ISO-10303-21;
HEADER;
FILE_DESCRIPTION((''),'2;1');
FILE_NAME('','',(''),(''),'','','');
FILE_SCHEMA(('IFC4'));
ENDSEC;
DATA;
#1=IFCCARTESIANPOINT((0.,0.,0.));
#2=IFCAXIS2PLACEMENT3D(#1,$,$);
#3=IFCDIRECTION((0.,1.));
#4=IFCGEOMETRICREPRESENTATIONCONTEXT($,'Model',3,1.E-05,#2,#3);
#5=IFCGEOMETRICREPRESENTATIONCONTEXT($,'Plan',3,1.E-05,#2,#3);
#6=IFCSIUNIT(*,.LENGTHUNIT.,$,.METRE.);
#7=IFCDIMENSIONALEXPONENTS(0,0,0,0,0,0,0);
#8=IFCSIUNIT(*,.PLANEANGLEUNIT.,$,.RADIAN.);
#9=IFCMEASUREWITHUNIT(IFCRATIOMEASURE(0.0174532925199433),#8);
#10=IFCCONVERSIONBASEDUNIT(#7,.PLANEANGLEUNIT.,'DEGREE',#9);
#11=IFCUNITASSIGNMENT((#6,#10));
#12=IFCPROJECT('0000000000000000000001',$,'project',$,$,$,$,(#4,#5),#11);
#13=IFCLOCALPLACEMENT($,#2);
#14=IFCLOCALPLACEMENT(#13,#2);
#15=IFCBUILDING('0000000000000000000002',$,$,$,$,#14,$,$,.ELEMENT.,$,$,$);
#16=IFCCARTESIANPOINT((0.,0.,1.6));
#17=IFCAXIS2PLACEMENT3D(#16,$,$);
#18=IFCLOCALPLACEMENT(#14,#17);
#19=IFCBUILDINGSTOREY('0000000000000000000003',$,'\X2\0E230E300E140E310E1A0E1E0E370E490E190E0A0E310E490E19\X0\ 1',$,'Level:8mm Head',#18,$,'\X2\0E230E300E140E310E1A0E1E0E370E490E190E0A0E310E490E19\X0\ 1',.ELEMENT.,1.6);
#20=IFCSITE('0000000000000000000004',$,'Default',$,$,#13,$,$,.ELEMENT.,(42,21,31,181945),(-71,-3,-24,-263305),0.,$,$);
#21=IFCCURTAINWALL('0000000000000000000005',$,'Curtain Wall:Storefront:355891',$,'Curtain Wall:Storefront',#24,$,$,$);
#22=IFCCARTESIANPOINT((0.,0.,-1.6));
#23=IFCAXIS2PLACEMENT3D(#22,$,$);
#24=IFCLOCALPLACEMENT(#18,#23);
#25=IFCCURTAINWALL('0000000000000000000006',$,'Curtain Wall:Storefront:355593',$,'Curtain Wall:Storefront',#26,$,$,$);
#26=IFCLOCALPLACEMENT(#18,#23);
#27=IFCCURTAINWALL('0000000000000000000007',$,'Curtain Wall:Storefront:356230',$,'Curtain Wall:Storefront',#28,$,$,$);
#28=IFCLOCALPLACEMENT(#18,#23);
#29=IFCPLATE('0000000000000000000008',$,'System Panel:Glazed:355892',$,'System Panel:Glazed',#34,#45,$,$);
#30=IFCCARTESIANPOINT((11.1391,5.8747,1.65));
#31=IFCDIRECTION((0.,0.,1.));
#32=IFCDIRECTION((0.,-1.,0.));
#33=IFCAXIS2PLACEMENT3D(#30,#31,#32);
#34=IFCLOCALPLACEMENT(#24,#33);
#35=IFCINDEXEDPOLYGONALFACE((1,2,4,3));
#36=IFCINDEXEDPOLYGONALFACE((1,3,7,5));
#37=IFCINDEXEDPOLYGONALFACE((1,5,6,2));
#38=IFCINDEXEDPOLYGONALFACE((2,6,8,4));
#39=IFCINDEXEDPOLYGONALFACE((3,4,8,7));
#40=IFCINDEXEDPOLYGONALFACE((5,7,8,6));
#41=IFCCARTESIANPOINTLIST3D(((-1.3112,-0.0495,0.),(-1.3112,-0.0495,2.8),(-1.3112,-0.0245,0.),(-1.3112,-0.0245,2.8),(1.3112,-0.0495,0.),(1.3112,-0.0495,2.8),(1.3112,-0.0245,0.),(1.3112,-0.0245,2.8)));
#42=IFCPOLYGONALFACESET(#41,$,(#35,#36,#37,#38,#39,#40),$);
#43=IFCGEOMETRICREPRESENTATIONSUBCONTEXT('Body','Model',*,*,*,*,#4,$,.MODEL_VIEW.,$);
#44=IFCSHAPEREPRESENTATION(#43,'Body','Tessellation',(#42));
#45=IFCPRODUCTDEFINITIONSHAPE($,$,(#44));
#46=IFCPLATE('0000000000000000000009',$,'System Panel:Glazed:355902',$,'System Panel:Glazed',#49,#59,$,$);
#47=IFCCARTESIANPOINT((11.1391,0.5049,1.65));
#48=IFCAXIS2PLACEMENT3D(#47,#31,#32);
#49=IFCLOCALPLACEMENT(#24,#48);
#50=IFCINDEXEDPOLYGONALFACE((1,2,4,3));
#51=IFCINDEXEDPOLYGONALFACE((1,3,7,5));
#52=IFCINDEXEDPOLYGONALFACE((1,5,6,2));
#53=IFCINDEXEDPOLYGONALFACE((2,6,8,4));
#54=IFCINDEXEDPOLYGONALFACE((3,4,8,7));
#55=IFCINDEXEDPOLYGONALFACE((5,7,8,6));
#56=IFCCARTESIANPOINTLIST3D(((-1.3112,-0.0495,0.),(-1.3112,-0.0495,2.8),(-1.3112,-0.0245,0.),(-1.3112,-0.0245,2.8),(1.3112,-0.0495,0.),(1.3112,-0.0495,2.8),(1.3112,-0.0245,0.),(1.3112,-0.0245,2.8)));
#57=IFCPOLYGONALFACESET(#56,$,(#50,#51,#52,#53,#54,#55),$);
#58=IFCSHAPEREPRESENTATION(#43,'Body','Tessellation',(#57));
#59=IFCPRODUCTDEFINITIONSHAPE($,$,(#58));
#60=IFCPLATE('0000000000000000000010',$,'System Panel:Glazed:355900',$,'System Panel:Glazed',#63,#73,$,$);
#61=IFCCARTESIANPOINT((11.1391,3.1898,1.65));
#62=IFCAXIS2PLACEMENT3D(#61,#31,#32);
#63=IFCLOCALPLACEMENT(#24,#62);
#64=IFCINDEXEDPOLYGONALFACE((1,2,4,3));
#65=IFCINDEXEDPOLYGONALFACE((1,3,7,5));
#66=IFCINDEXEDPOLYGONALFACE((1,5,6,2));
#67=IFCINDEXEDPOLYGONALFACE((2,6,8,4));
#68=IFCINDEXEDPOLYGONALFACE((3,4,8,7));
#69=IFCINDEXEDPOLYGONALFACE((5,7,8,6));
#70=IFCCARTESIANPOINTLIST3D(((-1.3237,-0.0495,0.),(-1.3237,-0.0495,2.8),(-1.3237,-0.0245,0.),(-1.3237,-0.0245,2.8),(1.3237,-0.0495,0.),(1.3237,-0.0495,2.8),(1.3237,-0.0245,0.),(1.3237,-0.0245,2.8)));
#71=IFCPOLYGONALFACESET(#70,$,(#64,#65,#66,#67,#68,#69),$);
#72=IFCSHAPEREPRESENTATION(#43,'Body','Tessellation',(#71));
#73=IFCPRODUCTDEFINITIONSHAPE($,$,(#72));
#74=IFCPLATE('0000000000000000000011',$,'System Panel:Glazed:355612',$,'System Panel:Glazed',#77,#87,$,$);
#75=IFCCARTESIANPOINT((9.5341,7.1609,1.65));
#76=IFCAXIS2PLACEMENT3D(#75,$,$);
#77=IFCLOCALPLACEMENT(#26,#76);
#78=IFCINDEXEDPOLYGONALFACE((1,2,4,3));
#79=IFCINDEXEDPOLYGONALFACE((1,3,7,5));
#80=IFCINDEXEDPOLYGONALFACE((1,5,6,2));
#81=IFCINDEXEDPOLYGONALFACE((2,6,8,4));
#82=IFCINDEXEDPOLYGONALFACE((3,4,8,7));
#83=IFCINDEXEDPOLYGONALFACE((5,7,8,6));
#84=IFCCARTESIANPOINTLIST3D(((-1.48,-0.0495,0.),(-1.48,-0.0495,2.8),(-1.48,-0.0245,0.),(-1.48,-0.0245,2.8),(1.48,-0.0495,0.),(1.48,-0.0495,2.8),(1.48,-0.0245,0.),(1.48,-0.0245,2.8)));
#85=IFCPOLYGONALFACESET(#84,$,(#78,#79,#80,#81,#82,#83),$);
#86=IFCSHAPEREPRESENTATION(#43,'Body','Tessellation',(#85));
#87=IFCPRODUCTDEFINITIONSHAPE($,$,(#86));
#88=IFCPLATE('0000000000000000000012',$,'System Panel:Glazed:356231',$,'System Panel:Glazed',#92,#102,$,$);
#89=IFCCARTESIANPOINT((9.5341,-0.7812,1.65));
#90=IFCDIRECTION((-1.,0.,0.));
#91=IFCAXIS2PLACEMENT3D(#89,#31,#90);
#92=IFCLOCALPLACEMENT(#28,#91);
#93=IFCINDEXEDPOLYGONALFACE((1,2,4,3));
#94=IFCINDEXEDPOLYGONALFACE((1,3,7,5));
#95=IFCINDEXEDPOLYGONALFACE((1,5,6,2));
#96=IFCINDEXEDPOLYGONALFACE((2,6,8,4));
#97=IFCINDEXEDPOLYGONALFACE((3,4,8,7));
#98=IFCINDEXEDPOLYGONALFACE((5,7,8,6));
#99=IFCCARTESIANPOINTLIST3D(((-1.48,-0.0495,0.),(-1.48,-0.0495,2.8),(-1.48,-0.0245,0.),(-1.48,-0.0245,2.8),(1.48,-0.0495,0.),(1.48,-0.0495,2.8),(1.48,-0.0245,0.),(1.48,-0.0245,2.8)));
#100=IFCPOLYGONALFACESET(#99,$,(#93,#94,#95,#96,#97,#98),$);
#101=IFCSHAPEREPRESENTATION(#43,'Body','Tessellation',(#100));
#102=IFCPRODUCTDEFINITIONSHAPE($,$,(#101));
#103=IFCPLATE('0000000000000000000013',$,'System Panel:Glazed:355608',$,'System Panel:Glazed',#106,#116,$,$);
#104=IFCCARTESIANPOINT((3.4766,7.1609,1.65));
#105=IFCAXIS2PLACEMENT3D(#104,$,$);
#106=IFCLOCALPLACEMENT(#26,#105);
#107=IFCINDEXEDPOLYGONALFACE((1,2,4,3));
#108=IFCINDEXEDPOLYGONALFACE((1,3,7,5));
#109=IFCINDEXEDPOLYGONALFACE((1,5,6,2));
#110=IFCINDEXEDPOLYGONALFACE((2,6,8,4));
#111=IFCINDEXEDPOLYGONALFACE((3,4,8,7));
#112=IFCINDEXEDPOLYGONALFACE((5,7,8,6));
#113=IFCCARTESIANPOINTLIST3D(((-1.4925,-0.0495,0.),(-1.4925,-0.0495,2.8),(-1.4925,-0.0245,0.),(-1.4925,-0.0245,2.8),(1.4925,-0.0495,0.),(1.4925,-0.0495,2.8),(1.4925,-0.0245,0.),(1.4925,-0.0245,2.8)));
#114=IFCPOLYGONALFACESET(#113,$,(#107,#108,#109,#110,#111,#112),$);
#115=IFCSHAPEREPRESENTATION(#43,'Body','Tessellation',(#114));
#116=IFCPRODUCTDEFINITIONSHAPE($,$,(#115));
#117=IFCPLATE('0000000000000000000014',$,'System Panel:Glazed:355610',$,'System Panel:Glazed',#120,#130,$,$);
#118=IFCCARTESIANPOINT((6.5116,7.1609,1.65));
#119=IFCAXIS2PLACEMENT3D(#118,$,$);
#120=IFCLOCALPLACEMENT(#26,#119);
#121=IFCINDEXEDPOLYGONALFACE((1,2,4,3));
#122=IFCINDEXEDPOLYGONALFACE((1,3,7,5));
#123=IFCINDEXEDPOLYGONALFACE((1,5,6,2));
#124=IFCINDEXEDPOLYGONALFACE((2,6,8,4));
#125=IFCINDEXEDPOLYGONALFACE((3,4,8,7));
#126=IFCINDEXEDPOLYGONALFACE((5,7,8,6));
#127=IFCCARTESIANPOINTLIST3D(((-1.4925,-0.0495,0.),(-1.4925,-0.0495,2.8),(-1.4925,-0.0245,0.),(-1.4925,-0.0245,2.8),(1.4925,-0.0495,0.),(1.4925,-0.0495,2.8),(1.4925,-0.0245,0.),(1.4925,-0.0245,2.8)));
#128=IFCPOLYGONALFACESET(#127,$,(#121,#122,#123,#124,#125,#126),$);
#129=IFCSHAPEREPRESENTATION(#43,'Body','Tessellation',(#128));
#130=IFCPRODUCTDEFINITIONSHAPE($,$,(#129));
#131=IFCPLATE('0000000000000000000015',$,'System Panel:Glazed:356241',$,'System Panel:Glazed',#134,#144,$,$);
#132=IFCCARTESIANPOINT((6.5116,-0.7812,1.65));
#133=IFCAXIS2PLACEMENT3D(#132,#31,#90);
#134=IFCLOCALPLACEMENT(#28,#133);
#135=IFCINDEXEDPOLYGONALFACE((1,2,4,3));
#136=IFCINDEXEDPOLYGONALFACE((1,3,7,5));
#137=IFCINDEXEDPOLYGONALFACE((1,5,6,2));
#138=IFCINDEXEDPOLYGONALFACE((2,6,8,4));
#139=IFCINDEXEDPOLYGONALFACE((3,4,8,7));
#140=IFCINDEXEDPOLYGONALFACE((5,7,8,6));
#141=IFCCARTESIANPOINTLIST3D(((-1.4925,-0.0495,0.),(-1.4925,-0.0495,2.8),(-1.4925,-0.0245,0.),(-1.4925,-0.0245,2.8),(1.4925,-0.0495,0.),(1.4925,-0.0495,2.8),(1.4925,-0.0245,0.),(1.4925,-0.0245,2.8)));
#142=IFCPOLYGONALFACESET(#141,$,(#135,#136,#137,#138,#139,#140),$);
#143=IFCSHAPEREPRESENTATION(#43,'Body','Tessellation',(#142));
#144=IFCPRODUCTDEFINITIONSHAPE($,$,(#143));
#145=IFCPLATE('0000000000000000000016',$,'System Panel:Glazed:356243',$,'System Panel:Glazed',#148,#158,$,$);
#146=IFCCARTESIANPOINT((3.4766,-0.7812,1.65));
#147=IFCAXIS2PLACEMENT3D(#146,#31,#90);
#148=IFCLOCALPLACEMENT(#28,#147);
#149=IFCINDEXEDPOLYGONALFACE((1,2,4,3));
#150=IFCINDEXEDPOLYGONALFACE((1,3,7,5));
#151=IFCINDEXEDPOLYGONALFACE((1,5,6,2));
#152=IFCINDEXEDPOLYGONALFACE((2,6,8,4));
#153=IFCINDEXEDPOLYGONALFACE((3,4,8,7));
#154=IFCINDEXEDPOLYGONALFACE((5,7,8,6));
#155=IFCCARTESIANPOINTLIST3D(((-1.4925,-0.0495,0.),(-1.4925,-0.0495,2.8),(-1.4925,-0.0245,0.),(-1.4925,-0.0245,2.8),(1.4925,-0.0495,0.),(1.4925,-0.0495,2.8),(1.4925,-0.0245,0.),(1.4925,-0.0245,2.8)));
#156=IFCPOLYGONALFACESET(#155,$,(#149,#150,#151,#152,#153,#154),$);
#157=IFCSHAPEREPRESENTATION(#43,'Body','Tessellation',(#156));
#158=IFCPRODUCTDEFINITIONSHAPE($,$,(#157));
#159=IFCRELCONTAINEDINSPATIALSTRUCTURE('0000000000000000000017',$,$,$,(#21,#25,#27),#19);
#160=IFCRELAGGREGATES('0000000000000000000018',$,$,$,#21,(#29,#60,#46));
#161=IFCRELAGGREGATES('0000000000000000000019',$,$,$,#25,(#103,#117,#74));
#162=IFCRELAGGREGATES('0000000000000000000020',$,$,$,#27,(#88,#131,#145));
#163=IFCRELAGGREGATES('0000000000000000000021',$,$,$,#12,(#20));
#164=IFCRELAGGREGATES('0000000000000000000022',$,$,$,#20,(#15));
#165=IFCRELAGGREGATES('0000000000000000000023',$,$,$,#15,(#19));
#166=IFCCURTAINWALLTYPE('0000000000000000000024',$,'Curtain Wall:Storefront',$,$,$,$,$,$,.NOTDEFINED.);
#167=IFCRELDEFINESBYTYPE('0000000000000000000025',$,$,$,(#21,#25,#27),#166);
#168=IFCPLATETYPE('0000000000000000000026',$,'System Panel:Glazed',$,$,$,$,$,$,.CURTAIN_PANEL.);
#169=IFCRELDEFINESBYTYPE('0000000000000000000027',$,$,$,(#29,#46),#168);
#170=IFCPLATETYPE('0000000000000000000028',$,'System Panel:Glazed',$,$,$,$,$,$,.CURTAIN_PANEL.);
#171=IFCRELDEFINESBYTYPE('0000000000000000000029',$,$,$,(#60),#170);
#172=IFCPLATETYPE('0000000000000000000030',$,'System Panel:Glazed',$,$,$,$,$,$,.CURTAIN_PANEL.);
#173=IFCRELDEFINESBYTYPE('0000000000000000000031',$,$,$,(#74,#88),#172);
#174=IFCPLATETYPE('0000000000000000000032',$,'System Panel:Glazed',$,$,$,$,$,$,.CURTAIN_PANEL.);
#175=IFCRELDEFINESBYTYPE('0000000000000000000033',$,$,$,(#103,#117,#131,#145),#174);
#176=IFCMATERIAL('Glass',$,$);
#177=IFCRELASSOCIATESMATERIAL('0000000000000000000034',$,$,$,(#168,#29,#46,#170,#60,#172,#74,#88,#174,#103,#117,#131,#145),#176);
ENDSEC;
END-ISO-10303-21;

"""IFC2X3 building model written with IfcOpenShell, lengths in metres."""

from ifc_helpers import new_model, entity, si_unit, converted_unit, direction, frame, frame_2d, origin, origin_2d_with_axis, place, context, subcontext, project, spatial, rectangle, extrude, source, transform, mapped, material, type_object, type_shapes, element, aggregate, save


model = new_model("IFC2X3")

# Units and contexts
model_context = context("Model", 3, precision=1e-05, world=origin(), true_north=direction((0.0, 1.0)))
plan_context = context("Plan", 3, precision=1e-05, world=origin(), true_north=direction((0.0, 1.0)))
body_context = subcontext(model_context, "Body", "Model", "MODEL_VIEW")
ifc_project = project(units=[si_unit("LENGTHUNIT", "METRE"), converted_unit("PLANEANGLEUNIT", "DEGREE", entity("IfcRatioMeasure", 0.0174532925199433), si_unit("PLANEANGLEUNIT", "RADIAN"), dimensions=[0, 0, 0, 0, 0, 0, 0])], contexts=[model_context, plan_context])

# Site, building, storey
site_placement = place(None, origin())
site = spatial("IfcSite", under=ifc_project, at=site_placement, Name="Default", CompositionType="ELEMENT", RefLatitude=(42, 21, 31, 181945), RefLongitude=(-71, -3, -24, -263305), RefElevation=0.0)
building_placement = place(site_placement, origin())
building = spatial("IfcBuilding", under=site, at=building_placement, CompositionType="ELEMENT")
storey_placement = place(building_placement, frame((0.0, 0.0, 1.6)))
storey = spatial("IfcBuildingStorey", under=building, at=storey_placement, Name="ระดับพื้นชั้น 1", ObjectType="Level:8mm Head", LongName="ระดับพื้นชั้น 1", CompositionType="ELEMENT", Elevation=1.6)

# Curtain wall
curtain_wall_type = type_object("IfcCurtainWallType", Name="Curtain Wall:Storefront", PredefinedType="NOTDEFINED")
curtain_wall_1_placement = place(storey_placement, frame((0.0, 0.0, -1.6)))
curtain_wall_1 = element("IfcCurtainWall", 1, at=curtain_wall_1_placement, inside=storey, type_object=curtain_wall_type, Name="Curtain Wall:Storefront:355891", ObjectType="Curtain Wall:Storefront")

# Curtain wall
curtain_wall_2_placement = place(storey_placement, frame((0.0, 0.0, -1.6)))
curtain_wall_2 = element("IfcCurtainWall", 2, at=curtain_wall_2_placement, inside=storey, type_object=curtain_wall_type, Name="Curtain Wall:Storefront:355593", ObjectType="Curtain Wall:Storefront")

# Curtain wall
curtain_wall_3_placement = place(storey_placement, frame((0.0, 0.0, -1.6)))
curtain_wall_3 = element("IfcCurtainWall", 3, at=curtain_wall_3_placement, inside=storey, type_object=curtain_wall_type, Name="Curtain Wall:Storefront:356230", ObjectType="Curtain Wall:Storefront")

# Plates
ifc_material_1 = material(Name="Glass")
plate_type_1 = type_object("IfcPlateType", Name="System Panel:Glazed", PredefinedType="CURTAIN_PANEL", material=ifc_material_1)
shared_shape_1 = source(origin(), body_context, "Body", "SweptSolid", [
    extrude(rectangle(XDim=0.025, YDim=2.6224, at=frame_2d((0.0, 0.0), x_axis=(1.0, 0.0))), frame((0.0, -0.037, 0.0), z_axis=(0.0, 0.0, 1.0), x_axis=(0.0, 1.0, 0.0)), (0.0, 0.0, 1.0), 2.8),
])
type_shapes(plate_type_1, [shared_shape_1])
plate_1_placement = place(curtain_wall_1_placement, frame((11.1391, 5.8747, 1.65), z_axis=(0.0, 0.0, 1.0), x_axis=(0.0, -1.0, 0.0)))
plate_1 = element("IfcPlate", 4, at=plate_1_placement, type_object=plate_type_1, material=ifc_material_1, Name="System Panel:Glazed:355892", ObjectType="System Panel:Glazed", context=body_context, shape_type="MappedRepresentation", body=[
    mapped(shared_shape_1, transform((0.0, 0.0, 0.0), scale=1.0)),
])
plate_2_placement = place(curtain_wall_1_placement, frame((11.1391, 0.5049, 1.65), z_axis=(0.0, 0.0, 1.0), x_axis=(0.0, -1.0, 0.0)))
plate_2 = element("IfcPlate", 5, at=plate_2_placement, type_object=plate_type_1, material=ifc_material_1, Name="System Panel:Glazed:355902", ObjectType="System Panel:Glazed", context=body_context, shape_type="MappedRepresentation", body=[
    mapped(shared_shape_1, transform((0.0, 0.0, 0.0), scale=1.0)),
])
plate_type_2 = type_object("IfcPlateType", Name="System Panel:Glazed", PredefinedType="CURTAIN_PANEL", material=ifc_material_1)
shared_shape_2 = source(origin(), body_context, "Body", "SweptSolid", [
    extrude(rectangle(XDim=0.025, YDim=2.6474, at=origin_2d_with_axis()), frame((0.0, -0.037, 0.0), z_axis=(0.0, 0.0, 1.0), x_axis=(0.0, 1.0, 0.0)), (0.0, 0.0, 1.0), 2.8),
])
type_shapes(plate_type_2, [shared_shape_2])
plate_3_placement = place(curtain_wall_1_placement, frame((11.1391, 3.1898, 1.65), z_axis=(0.0, 0.0, 1.0), x_axis=(0.0, -1.0, 0.0)))
plate_3 = element("IfcPlate", 6, at=plate_3_placement, type_object=plate_type_2, material=ifc_material_1, Name="System Panel:Glazed:355900", ObjectType="System Panel:Glazed", context=body_context, shape_type="MappedRepresentation", body=[
    mapped(shared_shape_2, transform((0.0, 0.0, 0.0), scale=1.0)),
])
aggregate(curtain_wall_1, [plate_1, plate_3, plate_2])
plate_type_3 = type_object("IfcPlateType", Name="System Panel:Glazed", PredefinedType="CURTAIN_PANEL", material=ifc_material_1)
shared_shape_3 = source(origin(), body_context, "Body", "SweptSolid", [
    extrude(rectangle(XDim=0.025, YDim=2.96, at=frame_2d((0.0, 0.0), x_axis=(1.0, 0.0))), frame((0.0, -0.037, 0.0), z_axis=(0.0, 0.0, 1.0), x_axis=(0.0, 1.0, 0.0)), (0.0, 0.0, 1.0), 2.8),
])
type_shapes(plate_type_3, [shared_shape_3])
plate_4_placement = place(curtain_wall_2_placement, frame((9.5341, 7.1609, 1.65)))
plate_4 = element("IfcPlate", 7, at=plate_4_placement, type_object=plate_type_3, material=ifc_material_1, Name="System Panel:Glazed:355612", ObjectType="System Panel:Glazed", context=body_context, shape_type="MappedRepresentation", body=[
    mapped(shared_shape_3, transform((0.0, 0.0, 0.0), scale=1.0)),
])
plate_5_placement = place(curtain_wall_3_placement, frame((9.5341, -0.7812, 1.65), z_axis=(0.0, 0.0, 1.0), x_axis=(-1.0, 0.0, 0.0)))
plate_5 = element("IfcPlate", 8, at=plate_5_placement, type_object=plate_type_3, material=ifc_material_1, Name="System Panel:Glazed:356231", ObjectType="System Panel:Glazed", context=body_context, shape_type="MappedRepresentation", body=[
    mapped(shared_shape_3, transform((0.0, 0.0, 0.0), scale=1.0)),
])
plate_type_4 = type_object("IfcPlateType", Name="System Panel:Glazed", PredefinedType="CURTAIN_PANEL", material=ifc_material_1)
shared_shape_4 = source(origin(), body_context, "Body", "SweptSolid", [
    extrude(rectangle(XDim=0.025, YDim=2.985, at=frame_2d((0.0, 0.0), x_axis=(1.0, 0.0))), frame((0.0, -0.037, 0.0), z_axis=(0.0, 0.0, 1.0), x_axis=(0.0, 1.0, 0.0)), (0.0, 0.0, 1.0), 2.8),
])
type_shapes(plate_type_4, [shared_shape_4])
plate_6_placement = place(curtain_wall_2_placement, frame((3.4766, 7.1609, 1.65)))
plate_6 = element("IfcPlate", 9, at=plate_6_placement, type_object=plate_type_4, material=ifc_material_1, Name="System Panel:Glazed:355608", ObjectType="System Panel:Glazed", context=body_context, shape_type="MappedRepresentation", body=[
    mapped(shared_shape_4, transform((0.0, 0.0, 0.0), scale=1.0)),
])
plate_7_placement = place(curtain_wall_2_placement, frame((6.5116, 7.1609, 1.65)))
plate_7 = element("IfcPlate", 10, at=plate_7_placement, type_object=plate_type_4, material=ifc_material_1, Name="System Panel:Glazed:355610", ObjectType="System Panel:Glazed", context=body_context, shape_type="MappedRepresentation", body=[
    mapped(shared_shape_4, transform((0.0, 0.0, 0.0), scale=1.0)),
])
aggregate(curtain_wall_2, [plate_6, plate_7, plate_4])
plate_8_placement = place(curtain_wall_3_placement, frame((6.5116, -0.7812, 1.65), z_axis=(0.0, 0.0, 1.0), x_axis=(-1.0, 0.0, 0.0)))
plate_8 = element("IfcPlate", 11, at=plate_8_placement, type_object=plate_type_4, material=ifc_material_1, Name="System Panel:Glazed:356241", ObjectType="System Panel:Glazed", context=body_context, shape_type="MappedRepresentation", body=[
    mapped(shared_shape_4, transform((0.0, 0.0, 0.0), scale=1.0)),
])
plate_9_placement = place(curtain_wall_3_placement, frame((3.4766, -0.7812, 1.65), z_axis=(0.0, 0.0, 1.0), x_axis=(-1.0, 0.0, 0.0)))
plate_9 = element("IfcPlate", 12, at=plate_9_placement, type_object=plate_type_4, material=ifc_material_1, Name="System Panel:Glazed:356243", ObjectType="System Panel:Glazed", context=body_context, shape_type="MappedRepresentation", body=[
    mapped(shared_shape_4, transform((0.0, 0.0, 0.0), scale=1.0)),
])
aggregate(curtain_wall_3, [plate_5, plate_8, plate_9])

save(model, "model.ifc")
